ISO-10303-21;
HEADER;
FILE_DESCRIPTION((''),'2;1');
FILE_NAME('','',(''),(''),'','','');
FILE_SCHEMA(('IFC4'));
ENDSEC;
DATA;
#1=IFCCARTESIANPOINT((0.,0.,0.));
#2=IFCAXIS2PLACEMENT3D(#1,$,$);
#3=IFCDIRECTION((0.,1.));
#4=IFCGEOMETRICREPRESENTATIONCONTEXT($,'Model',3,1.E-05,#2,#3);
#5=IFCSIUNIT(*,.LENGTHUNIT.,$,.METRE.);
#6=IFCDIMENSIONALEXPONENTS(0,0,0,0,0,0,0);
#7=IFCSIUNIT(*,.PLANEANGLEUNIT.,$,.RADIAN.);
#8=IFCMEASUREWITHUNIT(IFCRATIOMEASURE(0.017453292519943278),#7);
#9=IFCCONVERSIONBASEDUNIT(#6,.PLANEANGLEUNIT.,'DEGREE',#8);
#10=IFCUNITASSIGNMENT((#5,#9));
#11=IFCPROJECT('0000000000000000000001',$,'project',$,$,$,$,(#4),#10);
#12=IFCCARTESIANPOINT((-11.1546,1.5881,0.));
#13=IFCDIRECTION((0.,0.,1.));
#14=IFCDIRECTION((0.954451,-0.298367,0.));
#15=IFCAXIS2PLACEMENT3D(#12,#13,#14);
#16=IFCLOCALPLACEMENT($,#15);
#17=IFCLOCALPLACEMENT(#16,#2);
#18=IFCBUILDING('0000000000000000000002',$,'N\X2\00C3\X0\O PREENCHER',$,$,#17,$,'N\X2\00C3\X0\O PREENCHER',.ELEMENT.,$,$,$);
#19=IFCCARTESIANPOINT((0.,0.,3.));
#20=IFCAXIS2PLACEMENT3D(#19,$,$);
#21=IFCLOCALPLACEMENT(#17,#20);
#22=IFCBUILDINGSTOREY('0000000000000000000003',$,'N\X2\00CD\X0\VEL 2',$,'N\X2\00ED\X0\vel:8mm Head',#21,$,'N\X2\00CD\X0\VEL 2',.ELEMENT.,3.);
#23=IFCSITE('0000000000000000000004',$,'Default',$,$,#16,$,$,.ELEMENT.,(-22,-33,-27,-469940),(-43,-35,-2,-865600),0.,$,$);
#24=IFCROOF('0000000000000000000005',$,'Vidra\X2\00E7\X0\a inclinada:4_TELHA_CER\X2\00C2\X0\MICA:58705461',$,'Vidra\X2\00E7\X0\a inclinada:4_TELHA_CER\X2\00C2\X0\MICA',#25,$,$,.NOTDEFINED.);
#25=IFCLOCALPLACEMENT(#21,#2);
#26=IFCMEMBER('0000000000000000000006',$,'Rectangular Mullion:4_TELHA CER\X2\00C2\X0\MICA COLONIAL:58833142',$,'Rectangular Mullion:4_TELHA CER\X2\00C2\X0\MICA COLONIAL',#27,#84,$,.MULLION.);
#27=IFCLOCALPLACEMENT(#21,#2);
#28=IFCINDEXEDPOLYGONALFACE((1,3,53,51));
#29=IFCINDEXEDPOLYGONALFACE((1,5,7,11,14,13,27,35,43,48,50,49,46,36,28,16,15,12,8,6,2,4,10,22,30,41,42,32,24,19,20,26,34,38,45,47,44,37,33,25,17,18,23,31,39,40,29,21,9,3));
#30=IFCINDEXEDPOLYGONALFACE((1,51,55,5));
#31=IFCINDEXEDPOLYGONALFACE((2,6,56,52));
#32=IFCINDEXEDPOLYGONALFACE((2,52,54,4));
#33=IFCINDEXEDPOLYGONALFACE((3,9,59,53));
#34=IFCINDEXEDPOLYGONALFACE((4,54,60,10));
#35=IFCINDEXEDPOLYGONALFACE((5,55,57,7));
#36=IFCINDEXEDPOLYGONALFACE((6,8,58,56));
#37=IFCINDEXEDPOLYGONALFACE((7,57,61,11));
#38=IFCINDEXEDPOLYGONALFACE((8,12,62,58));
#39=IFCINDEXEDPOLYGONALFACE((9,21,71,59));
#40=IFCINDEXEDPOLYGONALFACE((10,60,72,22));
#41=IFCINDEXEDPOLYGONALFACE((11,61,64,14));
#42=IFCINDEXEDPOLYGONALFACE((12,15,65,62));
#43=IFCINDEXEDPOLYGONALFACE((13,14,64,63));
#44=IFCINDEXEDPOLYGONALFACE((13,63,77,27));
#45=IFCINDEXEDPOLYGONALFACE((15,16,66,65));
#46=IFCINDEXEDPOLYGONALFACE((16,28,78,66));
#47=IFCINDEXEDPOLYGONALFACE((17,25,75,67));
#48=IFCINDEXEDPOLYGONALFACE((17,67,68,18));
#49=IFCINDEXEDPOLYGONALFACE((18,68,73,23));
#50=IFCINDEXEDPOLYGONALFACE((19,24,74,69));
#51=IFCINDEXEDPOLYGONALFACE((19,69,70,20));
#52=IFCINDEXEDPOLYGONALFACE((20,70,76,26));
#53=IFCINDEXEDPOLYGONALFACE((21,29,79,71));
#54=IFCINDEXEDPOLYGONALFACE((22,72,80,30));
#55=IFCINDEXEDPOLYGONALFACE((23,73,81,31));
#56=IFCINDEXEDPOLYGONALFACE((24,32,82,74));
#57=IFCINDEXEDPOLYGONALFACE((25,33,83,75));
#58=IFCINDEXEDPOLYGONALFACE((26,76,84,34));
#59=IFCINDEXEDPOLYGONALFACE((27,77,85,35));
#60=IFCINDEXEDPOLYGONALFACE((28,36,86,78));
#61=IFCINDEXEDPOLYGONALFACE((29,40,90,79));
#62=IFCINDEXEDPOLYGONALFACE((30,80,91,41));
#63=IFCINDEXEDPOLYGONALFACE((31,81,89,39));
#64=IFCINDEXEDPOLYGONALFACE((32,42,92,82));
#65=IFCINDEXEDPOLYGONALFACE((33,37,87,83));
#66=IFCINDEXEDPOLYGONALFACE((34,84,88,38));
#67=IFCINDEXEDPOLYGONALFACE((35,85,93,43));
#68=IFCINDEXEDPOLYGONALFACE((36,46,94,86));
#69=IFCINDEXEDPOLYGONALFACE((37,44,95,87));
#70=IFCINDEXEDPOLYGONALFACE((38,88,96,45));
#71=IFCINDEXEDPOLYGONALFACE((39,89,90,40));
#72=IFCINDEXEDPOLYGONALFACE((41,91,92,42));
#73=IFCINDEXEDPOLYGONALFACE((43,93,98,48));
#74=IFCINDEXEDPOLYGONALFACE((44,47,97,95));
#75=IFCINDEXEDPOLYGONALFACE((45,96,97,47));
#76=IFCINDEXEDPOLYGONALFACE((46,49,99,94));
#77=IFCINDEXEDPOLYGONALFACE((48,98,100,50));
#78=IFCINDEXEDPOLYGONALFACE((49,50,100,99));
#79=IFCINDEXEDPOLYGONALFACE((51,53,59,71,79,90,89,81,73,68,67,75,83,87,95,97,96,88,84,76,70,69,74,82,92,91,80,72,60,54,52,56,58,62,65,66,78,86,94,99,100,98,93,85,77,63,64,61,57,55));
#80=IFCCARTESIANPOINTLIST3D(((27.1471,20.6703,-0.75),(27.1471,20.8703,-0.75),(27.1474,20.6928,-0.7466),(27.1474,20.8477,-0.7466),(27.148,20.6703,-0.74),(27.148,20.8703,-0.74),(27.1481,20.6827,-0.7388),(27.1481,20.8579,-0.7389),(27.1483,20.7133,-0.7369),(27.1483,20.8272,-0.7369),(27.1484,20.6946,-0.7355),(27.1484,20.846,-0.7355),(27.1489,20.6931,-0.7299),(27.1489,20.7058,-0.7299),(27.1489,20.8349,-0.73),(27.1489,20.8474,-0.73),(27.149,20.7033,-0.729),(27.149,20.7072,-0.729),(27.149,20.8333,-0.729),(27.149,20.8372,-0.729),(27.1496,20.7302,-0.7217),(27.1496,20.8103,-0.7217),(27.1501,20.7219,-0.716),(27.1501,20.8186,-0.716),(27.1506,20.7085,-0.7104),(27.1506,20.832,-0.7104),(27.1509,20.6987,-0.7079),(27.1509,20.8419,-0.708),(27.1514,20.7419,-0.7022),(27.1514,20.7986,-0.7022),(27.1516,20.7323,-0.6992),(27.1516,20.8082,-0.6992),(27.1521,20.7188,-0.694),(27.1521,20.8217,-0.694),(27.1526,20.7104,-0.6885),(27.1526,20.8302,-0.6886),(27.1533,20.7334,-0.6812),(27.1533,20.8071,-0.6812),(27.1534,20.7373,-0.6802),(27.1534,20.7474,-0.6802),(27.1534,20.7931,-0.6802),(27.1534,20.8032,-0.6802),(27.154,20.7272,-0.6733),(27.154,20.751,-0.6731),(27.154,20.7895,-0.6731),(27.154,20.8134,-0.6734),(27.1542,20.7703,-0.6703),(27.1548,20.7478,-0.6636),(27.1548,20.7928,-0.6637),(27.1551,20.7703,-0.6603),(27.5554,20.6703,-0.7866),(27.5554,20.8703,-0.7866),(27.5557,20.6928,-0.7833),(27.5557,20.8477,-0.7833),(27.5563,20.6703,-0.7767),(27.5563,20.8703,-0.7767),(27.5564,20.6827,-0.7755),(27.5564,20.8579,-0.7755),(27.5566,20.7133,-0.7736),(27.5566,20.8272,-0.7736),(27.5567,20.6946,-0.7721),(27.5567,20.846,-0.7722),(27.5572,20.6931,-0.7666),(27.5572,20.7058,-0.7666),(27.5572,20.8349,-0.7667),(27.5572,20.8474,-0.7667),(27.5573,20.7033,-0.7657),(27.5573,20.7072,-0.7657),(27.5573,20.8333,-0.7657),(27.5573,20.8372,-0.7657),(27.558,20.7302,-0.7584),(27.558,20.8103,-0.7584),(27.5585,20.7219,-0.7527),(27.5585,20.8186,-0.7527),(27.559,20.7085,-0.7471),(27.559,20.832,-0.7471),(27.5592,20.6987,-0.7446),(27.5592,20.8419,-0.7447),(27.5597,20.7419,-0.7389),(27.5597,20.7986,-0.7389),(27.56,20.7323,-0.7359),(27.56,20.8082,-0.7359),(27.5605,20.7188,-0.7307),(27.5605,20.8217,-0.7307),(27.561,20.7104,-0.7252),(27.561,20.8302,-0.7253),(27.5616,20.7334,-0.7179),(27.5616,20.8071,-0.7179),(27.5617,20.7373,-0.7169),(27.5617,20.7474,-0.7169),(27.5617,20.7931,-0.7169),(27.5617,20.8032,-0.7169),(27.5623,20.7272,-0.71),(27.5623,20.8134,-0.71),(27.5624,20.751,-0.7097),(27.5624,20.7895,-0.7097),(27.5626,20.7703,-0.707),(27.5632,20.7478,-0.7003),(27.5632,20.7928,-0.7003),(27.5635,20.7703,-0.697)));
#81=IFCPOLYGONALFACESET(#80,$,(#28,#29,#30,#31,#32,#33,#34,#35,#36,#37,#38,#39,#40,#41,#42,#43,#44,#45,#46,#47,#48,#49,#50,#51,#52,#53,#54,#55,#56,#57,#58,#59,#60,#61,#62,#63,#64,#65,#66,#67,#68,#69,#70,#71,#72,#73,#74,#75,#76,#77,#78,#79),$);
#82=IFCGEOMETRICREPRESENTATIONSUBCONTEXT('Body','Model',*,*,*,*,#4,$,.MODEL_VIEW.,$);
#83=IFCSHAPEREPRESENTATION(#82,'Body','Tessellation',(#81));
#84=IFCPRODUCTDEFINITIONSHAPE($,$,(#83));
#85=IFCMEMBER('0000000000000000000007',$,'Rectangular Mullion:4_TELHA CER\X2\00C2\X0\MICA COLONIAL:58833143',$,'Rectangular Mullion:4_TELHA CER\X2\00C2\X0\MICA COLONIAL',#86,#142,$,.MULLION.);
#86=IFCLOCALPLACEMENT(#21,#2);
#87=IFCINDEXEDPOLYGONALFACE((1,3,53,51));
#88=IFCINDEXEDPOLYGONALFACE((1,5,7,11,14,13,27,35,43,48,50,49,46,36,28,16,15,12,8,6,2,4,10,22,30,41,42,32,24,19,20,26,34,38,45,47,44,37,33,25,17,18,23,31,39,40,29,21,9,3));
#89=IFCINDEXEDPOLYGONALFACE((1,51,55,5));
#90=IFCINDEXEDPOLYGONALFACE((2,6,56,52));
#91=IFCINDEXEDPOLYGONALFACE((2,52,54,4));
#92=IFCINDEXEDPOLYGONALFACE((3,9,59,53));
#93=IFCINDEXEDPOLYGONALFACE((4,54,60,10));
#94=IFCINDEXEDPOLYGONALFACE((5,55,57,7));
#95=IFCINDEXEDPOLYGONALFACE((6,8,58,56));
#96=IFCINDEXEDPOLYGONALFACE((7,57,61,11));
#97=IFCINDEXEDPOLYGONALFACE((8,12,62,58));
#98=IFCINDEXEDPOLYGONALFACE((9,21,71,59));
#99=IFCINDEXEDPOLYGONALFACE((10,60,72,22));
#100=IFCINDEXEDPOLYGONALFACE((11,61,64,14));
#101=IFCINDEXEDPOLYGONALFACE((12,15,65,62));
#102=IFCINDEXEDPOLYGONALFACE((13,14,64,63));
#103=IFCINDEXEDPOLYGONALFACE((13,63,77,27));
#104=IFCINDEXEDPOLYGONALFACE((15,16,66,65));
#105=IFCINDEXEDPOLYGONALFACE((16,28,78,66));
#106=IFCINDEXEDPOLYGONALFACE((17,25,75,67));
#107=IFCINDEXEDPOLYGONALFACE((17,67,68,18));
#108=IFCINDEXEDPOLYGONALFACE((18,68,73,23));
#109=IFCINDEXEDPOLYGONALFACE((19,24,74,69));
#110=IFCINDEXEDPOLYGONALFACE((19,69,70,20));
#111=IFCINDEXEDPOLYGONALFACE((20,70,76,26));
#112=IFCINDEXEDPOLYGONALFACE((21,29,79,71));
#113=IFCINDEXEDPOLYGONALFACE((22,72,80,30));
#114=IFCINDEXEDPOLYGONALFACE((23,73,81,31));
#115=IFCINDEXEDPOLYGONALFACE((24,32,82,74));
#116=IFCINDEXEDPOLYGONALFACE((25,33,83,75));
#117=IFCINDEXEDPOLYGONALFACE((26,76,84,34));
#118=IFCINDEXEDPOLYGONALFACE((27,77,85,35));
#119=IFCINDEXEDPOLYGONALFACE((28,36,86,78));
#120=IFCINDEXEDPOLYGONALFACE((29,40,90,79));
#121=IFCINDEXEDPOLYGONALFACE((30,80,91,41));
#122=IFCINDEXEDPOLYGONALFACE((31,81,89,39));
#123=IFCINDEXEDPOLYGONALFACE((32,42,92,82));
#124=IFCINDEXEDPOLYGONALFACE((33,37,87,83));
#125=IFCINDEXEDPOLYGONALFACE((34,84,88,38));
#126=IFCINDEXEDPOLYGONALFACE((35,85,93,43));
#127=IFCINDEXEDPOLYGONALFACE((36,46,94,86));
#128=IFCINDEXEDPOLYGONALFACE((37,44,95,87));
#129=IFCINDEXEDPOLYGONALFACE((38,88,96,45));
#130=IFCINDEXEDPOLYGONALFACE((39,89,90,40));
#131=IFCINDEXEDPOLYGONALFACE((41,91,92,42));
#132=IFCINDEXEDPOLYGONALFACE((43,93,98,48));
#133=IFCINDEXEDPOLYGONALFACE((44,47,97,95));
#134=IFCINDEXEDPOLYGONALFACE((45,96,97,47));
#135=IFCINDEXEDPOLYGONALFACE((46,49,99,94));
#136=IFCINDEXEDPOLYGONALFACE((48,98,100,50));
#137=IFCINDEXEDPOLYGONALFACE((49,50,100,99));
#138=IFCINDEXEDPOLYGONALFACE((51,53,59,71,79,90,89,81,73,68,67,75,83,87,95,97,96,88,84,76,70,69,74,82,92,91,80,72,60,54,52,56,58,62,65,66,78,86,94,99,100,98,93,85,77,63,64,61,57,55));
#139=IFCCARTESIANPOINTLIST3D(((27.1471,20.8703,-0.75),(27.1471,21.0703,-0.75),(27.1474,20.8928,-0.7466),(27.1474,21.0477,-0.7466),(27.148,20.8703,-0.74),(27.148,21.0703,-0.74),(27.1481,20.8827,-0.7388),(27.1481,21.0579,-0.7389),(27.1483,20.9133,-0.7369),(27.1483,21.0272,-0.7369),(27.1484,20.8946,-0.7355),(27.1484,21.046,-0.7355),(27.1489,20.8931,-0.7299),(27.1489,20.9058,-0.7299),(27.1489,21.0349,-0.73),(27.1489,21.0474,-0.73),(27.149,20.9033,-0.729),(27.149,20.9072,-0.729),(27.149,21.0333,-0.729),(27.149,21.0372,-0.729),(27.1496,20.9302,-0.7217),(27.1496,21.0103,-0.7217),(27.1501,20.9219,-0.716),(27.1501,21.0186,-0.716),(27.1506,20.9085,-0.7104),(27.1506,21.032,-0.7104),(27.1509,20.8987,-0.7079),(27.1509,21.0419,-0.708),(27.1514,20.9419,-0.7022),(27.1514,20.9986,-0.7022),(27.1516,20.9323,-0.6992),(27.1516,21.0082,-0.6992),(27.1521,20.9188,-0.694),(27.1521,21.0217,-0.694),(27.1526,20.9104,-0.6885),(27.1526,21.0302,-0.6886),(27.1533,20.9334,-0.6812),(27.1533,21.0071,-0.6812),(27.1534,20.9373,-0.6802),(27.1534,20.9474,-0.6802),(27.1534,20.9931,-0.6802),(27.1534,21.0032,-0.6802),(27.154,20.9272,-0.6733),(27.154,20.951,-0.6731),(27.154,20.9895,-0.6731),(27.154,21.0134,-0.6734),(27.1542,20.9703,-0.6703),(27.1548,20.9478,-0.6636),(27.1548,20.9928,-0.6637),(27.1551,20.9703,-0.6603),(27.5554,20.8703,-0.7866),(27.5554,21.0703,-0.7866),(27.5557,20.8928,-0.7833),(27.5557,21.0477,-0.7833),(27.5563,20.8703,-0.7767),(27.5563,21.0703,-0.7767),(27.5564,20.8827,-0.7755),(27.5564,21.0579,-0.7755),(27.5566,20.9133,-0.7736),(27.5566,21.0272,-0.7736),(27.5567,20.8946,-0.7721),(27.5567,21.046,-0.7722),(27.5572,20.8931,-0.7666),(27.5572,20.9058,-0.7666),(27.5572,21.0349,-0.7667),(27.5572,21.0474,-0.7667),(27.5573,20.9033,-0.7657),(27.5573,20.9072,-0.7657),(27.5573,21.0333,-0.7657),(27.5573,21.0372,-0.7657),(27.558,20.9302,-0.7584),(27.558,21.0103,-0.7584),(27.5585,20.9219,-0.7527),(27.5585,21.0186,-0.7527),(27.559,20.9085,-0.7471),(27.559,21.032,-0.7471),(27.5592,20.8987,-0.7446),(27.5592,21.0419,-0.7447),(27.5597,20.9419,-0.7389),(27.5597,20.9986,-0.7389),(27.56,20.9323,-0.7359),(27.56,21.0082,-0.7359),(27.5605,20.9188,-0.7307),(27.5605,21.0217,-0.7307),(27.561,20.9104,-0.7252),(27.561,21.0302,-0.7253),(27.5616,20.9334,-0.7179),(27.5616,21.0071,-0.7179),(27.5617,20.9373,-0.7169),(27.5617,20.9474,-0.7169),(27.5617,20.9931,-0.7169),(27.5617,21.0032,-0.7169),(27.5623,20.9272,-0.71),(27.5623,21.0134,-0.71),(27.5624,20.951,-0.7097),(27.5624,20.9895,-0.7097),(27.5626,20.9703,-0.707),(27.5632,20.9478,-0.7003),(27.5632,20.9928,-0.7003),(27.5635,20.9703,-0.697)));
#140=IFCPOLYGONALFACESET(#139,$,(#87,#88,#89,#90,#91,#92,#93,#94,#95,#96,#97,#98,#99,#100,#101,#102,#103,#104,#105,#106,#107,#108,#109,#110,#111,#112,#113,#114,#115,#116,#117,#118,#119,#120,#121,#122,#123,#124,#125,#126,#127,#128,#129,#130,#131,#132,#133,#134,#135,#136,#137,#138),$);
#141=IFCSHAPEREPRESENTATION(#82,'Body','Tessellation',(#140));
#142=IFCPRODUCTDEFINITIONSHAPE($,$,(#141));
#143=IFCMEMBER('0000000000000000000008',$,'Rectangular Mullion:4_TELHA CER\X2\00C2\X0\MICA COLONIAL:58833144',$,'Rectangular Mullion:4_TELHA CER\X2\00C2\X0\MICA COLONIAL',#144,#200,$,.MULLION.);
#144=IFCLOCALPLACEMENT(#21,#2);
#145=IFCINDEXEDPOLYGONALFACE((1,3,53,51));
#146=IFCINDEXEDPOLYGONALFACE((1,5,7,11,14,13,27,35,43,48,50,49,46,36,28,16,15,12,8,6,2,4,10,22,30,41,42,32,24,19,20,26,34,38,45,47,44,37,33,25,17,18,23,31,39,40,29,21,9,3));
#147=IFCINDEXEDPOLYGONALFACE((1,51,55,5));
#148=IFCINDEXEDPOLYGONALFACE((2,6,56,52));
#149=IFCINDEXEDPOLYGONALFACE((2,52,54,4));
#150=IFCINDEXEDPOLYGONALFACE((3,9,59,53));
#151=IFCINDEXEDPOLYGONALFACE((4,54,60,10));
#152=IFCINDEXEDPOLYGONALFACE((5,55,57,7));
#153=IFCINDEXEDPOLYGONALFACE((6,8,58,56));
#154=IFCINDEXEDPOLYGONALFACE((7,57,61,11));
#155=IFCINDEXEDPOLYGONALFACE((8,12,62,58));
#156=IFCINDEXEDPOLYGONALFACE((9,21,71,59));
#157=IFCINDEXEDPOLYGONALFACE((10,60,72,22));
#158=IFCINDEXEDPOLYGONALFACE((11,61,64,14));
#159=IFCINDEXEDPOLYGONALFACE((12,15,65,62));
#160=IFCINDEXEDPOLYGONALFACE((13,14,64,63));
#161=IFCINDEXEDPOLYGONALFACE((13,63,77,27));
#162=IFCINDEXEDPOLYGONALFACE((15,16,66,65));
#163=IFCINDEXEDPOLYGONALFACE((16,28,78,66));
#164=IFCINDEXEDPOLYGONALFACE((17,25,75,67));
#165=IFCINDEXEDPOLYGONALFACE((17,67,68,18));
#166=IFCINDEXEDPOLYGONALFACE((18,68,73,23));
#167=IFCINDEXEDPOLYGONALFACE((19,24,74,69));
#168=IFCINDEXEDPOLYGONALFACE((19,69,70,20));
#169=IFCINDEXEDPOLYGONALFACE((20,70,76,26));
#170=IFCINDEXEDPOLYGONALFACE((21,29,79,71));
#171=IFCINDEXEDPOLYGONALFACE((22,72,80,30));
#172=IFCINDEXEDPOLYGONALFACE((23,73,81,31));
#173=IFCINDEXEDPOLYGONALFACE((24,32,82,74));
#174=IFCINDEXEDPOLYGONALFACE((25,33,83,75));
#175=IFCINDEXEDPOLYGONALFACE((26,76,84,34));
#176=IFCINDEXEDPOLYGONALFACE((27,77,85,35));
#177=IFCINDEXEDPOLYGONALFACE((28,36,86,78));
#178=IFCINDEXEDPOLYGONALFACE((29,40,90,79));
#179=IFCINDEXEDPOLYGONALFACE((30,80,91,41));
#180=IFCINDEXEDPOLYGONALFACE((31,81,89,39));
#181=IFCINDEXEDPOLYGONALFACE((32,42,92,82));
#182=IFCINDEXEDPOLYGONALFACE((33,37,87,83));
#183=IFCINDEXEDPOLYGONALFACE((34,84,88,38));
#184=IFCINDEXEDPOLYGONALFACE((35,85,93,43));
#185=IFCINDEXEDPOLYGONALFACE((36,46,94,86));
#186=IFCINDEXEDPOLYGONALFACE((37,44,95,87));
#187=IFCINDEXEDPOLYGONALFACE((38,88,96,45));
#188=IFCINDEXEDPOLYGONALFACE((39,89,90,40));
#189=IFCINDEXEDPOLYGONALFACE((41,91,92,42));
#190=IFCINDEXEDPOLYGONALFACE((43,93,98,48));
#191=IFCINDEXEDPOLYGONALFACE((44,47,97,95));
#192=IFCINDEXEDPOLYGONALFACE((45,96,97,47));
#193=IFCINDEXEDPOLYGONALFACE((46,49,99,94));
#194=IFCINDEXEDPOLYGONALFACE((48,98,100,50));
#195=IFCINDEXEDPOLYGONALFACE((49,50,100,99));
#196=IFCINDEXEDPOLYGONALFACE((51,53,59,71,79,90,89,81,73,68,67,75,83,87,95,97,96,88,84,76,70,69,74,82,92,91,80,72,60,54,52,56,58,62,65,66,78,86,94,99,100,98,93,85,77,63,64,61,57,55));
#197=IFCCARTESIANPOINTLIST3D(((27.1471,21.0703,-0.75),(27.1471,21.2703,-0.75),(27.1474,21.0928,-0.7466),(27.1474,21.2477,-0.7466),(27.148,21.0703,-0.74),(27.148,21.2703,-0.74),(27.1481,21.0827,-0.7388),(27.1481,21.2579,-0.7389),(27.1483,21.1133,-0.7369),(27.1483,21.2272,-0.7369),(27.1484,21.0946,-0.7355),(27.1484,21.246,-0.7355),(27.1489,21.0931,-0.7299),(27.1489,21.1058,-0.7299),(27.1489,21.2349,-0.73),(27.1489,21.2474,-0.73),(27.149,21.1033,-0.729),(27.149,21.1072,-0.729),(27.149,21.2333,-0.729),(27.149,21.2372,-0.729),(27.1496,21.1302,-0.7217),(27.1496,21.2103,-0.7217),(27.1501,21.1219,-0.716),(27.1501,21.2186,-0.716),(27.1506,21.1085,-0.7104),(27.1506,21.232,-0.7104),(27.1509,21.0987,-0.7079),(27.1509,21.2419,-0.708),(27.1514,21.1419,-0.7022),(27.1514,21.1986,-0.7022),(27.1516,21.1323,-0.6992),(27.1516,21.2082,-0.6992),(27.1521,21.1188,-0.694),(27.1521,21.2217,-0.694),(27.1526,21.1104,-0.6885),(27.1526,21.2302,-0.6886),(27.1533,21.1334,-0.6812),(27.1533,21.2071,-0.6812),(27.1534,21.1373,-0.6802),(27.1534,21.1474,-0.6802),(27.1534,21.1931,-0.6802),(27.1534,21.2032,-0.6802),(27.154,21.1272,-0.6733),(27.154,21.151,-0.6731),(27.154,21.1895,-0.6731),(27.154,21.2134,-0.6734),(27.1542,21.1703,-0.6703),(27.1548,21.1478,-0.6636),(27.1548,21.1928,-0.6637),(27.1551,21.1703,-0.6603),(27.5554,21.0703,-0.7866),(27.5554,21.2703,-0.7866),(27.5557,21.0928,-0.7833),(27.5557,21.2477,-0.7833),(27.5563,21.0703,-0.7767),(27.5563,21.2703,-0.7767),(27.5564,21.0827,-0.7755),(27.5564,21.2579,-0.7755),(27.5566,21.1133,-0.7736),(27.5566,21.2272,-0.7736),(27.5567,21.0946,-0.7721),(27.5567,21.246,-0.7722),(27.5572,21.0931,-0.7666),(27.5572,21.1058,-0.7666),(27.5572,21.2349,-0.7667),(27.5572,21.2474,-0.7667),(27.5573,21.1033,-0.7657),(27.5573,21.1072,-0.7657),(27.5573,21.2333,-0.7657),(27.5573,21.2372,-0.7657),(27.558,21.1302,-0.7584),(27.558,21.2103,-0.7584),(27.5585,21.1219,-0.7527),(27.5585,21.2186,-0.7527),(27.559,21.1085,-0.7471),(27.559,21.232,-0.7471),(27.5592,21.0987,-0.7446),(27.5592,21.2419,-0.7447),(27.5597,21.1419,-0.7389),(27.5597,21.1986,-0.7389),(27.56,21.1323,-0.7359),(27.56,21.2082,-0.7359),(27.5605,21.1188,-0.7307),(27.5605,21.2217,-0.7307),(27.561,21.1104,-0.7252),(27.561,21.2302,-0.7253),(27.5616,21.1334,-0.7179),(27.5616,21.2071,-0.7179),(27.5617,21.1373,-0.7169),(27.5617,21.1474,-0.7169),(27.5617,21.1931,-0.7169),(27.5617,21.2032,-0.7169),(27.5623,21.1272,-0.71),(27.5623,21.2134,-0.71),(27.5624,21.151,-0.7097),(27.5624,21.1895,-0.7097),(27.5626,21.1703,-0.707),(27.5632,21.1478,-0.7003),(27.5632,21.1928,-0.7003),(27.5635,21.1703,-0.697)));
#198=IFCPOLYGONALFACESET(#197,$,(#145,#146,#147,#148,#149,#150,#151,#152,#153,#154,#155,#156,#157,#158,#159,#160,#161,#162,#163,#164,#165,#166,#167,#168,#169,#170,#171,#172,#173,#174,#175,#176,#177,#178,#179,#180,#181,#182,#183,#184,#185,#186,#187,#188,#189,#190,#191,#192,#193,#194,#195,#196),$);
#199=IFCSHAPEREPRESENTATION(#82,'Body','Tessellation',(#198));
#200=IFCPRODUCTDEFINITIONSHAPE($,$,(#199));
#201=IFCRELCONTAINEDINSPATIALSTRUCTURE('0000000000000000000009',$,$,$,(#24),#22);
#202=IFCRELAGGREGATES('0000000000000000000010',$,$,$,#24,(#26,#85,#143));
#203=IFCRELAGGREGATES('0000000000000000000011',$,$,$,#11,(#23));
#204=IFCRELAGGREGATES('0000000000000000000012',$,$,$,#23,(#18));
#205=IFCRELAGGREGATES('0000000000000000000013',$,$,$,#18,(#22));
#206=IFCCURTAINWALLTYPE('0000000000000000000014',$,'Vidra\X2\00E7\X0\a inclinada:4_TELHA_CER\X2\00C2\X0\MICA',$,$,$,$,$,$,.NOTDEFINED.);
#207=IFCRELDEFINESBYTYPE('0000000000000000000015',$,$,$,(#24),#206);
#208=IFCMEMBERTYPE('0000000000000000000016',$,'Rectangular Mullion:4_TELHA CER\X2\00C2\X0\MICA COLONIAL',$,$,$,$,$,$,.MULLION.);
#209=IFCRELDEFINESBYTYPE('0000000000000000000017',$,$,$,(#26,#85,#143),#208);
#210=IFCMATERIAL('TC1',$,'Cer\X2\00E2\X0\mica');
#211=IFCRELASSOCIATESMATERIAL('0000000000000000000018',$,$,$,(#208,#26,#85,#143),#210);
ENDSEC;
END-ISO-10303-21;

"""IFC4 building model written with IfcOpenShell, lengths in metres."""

from ifc_helpers import new_model, entity, si_unit, converted_unit, direction, frame, origin, place, context, subcontext, project, spatial, line, arc, indexed_curve, outline, extrude, source, transform, mapped, material, type_object, type_shapes, element, aggregate, save


model = new_model("IFC4")

# Units and contexts
model_context = context("Model", 3, precision=1e-05, world=origin(), true_north=direction((0.0, 1.0)))
body_context = subcontext(model_context, "Body", "Model", "MODEL_VIEW")
ifc_project = project(units=[si_unit("LENGTHUNIT", "METRE"), converted_unit("PLANEANGLEUNIT", "DEGREE", entity("IfcRatioMeasure", 0.017453292519943278), si_unit("PLANEANGLEUNIT", "RADIAN"), dimensions=[0, 0, 0, 0, 0, 0, 0])], contexts=[model_context])

# Site, building, storey
site_placement = place(None, frame((-11.1546, 1.5881, 0.0), z_axis=(0.0, 0.0, 1.0), x_axis=(0.954451, -0.298367, 0.0)))
site = spatial("IfcSite", under=ifc_project, at=site_placement, Name="Default", CompositionType="ELEMENT", RefLatitude=(-22, -33, -27, -469940), RefLongitude=(-43, -35, -2, -865600), RefElevation=0.0)
building_placement = place(site_placement, origin())
building = spatial("IfcBuilding", under=site, at=building_placement, Name="NÃO PREENCHER", LongName="NÃO PREENCHER", CompositionType="ELEMENT")
storey_placement = place(building_placement, frame((0.0, 0.0, 3.0)))
storey = spatial("IfcBuildingStorey", under=building, at=storey_placement, Name="NÍVEL 2", ObjectType="Nível:8mm Head", LongName="NÍVEL 2", CompositionType="ELEMENT", Elevation=3.0)

# Roof, members
curtain_wall_type = type_object("IfcCurtainWallType", Name="Vidraça inclinada:4_TELHA_CERÂMICA", PredefinedType="NOTDEFINED")
roof_placement = place(storey_placement, frame((0.0, 0.0, -3.0)))
roof = element("IfcRoof", 1, at=roof_placement, inside=storey, type_object=curtain_wall_type, Name="Vidraça inclinada:4_TELHA_CERÂMICA:58705461", ObjectType="Vidraça inclinada:4_TELHA_CERÂMICA", PredefinedType="NOTDEFINED")
ifc_material = material(Name="TC1", Category="Cerâmica")
member_type_1 = type_object("IfcMemberType", Name="Rectangular Mullion:4_TELHA CERÂMICA COLONIAL", PredefinedType="MULLION", material=ifc_material)
shared_shape_1 = source(origin(), body_context, "Body", "SweptSolid", [
    extrude(outline(indexed_curve([(-0.029, -0.1), (-0.019, -0.1), (-0.0164, -0.0815), (-0.0089, -0.0645), (-0.0089, -0.0771), (0.061, 0.0), (-0.009, 0.0771), (-0.009, 0.0646), (-0.0165, 0.0816), (-0.019, 0.1), (-0.029, 0.1), (-0.0089, 0.0479), (0.041, 0.0229), (0.041, 0.0329), (0.0131, 0.0425), (-0.008, 0.0631), (-0.008, 0.067), (0.051, 0.0), (-0.008, -0.067), (-0.008, -0.0631), (0.0131, -0.0425), (0.041, -0.0329), (0.041, -0.0229), (-0.0089, -0.0479)], segments=[line(1, 2), arc(2, 3, 4), line(4, 5), arc(5, 6, 7), line(7, 8), arc(8, 9, 10), line(10, 11), arc(11, 12, 13), line(13, 14), arc(14, 15, 16), line(16, 17), arc(17, 18, 19), line(19, 20), arc(20, 21, 22), line(22, 23), arc(23, 24, 1)], self_intersect=False)), frame((0.0, -0.029, -0.41), z_axis=(0.0, 0.0, 1.0), x_axis=(0.0, -1.0, 0.0)), (0.0, 0.0, 1.0), 0.41),
])
type_shapes(member_type_1, [shared_shape_1])
member_1_placement = place(roof_placement, frame((27.1471, 20.7703, 2.25), z_axis=(-0.99599, 0.0, 0.089469), x_axis=(0.0, 1.0, 0.0)))
member_1 = element("IfcMember", 2, at=member_1_placement, type_object=member_type_1, material=ifc_material, Name="Rectangular Mullion:4_TELHA CERÂMICA COLONIAL:58833142", ObjectType="Rectangular Mullion:4_TELHA CERÂMICA COLONIAL", PredefinedType="MULLION", context=body_context, shape_type="MappedRepresentation", body=[
    mapped(shared_shape_1, transform((0.0, 0.0, 0.0), scale=1.0)),
])
member_2_placement = place(roof_placement, frame((27.1471, 20.9703, 2.25), z_axis=(-0.99599, 0.0, 0.089469), x_axis=(0.0, 1.0, 0.0)))
member_2 = element("IfcMember", 3, at=member_2_placement, type_object=member_type_1, material=ifc_material, Name="Rectangular Mullion:4_TELHA CERÂMICA COLONIAL:58833143", ObjectType="Rectangular Mullion:4_TELHA CERÂMICA COLONIAL", PredefinedType="MULLION", context=body_context, shape_type="MappedRepresentation", body=[
    mapped(shared_shape_1, transform((0.0, 0.0, 0.0), scale=1.0)),
])
member_3_placement = place(roof_placement, frame((27.1471, 21.1703, 2.25), z_axis=(-0.99599, 0.0, 0.089469), x_axis=(0.0, 1.0, 0.0)))
member_3 = element("IfcMember", 4, at=member_3_placement, type_object=member_type_1, material=ifc_material, Name="Rectangular Mullion:4_TELHA CERÂMICA COLONIAL:58833144", ObjectType="Rectangular Mullion:4_TELHA CERÂMICA COLONIAL", PredefinedType="MULLION", context=body_context, shape_type="MappedRepresentation", body=[
    mapped(shared_shape_1, transform((0.0, 0.0, 0.0), scale=1.0)),
])
aggregate(roof, [member_1, member_2, member_3])

save(model, "model.ifc")
